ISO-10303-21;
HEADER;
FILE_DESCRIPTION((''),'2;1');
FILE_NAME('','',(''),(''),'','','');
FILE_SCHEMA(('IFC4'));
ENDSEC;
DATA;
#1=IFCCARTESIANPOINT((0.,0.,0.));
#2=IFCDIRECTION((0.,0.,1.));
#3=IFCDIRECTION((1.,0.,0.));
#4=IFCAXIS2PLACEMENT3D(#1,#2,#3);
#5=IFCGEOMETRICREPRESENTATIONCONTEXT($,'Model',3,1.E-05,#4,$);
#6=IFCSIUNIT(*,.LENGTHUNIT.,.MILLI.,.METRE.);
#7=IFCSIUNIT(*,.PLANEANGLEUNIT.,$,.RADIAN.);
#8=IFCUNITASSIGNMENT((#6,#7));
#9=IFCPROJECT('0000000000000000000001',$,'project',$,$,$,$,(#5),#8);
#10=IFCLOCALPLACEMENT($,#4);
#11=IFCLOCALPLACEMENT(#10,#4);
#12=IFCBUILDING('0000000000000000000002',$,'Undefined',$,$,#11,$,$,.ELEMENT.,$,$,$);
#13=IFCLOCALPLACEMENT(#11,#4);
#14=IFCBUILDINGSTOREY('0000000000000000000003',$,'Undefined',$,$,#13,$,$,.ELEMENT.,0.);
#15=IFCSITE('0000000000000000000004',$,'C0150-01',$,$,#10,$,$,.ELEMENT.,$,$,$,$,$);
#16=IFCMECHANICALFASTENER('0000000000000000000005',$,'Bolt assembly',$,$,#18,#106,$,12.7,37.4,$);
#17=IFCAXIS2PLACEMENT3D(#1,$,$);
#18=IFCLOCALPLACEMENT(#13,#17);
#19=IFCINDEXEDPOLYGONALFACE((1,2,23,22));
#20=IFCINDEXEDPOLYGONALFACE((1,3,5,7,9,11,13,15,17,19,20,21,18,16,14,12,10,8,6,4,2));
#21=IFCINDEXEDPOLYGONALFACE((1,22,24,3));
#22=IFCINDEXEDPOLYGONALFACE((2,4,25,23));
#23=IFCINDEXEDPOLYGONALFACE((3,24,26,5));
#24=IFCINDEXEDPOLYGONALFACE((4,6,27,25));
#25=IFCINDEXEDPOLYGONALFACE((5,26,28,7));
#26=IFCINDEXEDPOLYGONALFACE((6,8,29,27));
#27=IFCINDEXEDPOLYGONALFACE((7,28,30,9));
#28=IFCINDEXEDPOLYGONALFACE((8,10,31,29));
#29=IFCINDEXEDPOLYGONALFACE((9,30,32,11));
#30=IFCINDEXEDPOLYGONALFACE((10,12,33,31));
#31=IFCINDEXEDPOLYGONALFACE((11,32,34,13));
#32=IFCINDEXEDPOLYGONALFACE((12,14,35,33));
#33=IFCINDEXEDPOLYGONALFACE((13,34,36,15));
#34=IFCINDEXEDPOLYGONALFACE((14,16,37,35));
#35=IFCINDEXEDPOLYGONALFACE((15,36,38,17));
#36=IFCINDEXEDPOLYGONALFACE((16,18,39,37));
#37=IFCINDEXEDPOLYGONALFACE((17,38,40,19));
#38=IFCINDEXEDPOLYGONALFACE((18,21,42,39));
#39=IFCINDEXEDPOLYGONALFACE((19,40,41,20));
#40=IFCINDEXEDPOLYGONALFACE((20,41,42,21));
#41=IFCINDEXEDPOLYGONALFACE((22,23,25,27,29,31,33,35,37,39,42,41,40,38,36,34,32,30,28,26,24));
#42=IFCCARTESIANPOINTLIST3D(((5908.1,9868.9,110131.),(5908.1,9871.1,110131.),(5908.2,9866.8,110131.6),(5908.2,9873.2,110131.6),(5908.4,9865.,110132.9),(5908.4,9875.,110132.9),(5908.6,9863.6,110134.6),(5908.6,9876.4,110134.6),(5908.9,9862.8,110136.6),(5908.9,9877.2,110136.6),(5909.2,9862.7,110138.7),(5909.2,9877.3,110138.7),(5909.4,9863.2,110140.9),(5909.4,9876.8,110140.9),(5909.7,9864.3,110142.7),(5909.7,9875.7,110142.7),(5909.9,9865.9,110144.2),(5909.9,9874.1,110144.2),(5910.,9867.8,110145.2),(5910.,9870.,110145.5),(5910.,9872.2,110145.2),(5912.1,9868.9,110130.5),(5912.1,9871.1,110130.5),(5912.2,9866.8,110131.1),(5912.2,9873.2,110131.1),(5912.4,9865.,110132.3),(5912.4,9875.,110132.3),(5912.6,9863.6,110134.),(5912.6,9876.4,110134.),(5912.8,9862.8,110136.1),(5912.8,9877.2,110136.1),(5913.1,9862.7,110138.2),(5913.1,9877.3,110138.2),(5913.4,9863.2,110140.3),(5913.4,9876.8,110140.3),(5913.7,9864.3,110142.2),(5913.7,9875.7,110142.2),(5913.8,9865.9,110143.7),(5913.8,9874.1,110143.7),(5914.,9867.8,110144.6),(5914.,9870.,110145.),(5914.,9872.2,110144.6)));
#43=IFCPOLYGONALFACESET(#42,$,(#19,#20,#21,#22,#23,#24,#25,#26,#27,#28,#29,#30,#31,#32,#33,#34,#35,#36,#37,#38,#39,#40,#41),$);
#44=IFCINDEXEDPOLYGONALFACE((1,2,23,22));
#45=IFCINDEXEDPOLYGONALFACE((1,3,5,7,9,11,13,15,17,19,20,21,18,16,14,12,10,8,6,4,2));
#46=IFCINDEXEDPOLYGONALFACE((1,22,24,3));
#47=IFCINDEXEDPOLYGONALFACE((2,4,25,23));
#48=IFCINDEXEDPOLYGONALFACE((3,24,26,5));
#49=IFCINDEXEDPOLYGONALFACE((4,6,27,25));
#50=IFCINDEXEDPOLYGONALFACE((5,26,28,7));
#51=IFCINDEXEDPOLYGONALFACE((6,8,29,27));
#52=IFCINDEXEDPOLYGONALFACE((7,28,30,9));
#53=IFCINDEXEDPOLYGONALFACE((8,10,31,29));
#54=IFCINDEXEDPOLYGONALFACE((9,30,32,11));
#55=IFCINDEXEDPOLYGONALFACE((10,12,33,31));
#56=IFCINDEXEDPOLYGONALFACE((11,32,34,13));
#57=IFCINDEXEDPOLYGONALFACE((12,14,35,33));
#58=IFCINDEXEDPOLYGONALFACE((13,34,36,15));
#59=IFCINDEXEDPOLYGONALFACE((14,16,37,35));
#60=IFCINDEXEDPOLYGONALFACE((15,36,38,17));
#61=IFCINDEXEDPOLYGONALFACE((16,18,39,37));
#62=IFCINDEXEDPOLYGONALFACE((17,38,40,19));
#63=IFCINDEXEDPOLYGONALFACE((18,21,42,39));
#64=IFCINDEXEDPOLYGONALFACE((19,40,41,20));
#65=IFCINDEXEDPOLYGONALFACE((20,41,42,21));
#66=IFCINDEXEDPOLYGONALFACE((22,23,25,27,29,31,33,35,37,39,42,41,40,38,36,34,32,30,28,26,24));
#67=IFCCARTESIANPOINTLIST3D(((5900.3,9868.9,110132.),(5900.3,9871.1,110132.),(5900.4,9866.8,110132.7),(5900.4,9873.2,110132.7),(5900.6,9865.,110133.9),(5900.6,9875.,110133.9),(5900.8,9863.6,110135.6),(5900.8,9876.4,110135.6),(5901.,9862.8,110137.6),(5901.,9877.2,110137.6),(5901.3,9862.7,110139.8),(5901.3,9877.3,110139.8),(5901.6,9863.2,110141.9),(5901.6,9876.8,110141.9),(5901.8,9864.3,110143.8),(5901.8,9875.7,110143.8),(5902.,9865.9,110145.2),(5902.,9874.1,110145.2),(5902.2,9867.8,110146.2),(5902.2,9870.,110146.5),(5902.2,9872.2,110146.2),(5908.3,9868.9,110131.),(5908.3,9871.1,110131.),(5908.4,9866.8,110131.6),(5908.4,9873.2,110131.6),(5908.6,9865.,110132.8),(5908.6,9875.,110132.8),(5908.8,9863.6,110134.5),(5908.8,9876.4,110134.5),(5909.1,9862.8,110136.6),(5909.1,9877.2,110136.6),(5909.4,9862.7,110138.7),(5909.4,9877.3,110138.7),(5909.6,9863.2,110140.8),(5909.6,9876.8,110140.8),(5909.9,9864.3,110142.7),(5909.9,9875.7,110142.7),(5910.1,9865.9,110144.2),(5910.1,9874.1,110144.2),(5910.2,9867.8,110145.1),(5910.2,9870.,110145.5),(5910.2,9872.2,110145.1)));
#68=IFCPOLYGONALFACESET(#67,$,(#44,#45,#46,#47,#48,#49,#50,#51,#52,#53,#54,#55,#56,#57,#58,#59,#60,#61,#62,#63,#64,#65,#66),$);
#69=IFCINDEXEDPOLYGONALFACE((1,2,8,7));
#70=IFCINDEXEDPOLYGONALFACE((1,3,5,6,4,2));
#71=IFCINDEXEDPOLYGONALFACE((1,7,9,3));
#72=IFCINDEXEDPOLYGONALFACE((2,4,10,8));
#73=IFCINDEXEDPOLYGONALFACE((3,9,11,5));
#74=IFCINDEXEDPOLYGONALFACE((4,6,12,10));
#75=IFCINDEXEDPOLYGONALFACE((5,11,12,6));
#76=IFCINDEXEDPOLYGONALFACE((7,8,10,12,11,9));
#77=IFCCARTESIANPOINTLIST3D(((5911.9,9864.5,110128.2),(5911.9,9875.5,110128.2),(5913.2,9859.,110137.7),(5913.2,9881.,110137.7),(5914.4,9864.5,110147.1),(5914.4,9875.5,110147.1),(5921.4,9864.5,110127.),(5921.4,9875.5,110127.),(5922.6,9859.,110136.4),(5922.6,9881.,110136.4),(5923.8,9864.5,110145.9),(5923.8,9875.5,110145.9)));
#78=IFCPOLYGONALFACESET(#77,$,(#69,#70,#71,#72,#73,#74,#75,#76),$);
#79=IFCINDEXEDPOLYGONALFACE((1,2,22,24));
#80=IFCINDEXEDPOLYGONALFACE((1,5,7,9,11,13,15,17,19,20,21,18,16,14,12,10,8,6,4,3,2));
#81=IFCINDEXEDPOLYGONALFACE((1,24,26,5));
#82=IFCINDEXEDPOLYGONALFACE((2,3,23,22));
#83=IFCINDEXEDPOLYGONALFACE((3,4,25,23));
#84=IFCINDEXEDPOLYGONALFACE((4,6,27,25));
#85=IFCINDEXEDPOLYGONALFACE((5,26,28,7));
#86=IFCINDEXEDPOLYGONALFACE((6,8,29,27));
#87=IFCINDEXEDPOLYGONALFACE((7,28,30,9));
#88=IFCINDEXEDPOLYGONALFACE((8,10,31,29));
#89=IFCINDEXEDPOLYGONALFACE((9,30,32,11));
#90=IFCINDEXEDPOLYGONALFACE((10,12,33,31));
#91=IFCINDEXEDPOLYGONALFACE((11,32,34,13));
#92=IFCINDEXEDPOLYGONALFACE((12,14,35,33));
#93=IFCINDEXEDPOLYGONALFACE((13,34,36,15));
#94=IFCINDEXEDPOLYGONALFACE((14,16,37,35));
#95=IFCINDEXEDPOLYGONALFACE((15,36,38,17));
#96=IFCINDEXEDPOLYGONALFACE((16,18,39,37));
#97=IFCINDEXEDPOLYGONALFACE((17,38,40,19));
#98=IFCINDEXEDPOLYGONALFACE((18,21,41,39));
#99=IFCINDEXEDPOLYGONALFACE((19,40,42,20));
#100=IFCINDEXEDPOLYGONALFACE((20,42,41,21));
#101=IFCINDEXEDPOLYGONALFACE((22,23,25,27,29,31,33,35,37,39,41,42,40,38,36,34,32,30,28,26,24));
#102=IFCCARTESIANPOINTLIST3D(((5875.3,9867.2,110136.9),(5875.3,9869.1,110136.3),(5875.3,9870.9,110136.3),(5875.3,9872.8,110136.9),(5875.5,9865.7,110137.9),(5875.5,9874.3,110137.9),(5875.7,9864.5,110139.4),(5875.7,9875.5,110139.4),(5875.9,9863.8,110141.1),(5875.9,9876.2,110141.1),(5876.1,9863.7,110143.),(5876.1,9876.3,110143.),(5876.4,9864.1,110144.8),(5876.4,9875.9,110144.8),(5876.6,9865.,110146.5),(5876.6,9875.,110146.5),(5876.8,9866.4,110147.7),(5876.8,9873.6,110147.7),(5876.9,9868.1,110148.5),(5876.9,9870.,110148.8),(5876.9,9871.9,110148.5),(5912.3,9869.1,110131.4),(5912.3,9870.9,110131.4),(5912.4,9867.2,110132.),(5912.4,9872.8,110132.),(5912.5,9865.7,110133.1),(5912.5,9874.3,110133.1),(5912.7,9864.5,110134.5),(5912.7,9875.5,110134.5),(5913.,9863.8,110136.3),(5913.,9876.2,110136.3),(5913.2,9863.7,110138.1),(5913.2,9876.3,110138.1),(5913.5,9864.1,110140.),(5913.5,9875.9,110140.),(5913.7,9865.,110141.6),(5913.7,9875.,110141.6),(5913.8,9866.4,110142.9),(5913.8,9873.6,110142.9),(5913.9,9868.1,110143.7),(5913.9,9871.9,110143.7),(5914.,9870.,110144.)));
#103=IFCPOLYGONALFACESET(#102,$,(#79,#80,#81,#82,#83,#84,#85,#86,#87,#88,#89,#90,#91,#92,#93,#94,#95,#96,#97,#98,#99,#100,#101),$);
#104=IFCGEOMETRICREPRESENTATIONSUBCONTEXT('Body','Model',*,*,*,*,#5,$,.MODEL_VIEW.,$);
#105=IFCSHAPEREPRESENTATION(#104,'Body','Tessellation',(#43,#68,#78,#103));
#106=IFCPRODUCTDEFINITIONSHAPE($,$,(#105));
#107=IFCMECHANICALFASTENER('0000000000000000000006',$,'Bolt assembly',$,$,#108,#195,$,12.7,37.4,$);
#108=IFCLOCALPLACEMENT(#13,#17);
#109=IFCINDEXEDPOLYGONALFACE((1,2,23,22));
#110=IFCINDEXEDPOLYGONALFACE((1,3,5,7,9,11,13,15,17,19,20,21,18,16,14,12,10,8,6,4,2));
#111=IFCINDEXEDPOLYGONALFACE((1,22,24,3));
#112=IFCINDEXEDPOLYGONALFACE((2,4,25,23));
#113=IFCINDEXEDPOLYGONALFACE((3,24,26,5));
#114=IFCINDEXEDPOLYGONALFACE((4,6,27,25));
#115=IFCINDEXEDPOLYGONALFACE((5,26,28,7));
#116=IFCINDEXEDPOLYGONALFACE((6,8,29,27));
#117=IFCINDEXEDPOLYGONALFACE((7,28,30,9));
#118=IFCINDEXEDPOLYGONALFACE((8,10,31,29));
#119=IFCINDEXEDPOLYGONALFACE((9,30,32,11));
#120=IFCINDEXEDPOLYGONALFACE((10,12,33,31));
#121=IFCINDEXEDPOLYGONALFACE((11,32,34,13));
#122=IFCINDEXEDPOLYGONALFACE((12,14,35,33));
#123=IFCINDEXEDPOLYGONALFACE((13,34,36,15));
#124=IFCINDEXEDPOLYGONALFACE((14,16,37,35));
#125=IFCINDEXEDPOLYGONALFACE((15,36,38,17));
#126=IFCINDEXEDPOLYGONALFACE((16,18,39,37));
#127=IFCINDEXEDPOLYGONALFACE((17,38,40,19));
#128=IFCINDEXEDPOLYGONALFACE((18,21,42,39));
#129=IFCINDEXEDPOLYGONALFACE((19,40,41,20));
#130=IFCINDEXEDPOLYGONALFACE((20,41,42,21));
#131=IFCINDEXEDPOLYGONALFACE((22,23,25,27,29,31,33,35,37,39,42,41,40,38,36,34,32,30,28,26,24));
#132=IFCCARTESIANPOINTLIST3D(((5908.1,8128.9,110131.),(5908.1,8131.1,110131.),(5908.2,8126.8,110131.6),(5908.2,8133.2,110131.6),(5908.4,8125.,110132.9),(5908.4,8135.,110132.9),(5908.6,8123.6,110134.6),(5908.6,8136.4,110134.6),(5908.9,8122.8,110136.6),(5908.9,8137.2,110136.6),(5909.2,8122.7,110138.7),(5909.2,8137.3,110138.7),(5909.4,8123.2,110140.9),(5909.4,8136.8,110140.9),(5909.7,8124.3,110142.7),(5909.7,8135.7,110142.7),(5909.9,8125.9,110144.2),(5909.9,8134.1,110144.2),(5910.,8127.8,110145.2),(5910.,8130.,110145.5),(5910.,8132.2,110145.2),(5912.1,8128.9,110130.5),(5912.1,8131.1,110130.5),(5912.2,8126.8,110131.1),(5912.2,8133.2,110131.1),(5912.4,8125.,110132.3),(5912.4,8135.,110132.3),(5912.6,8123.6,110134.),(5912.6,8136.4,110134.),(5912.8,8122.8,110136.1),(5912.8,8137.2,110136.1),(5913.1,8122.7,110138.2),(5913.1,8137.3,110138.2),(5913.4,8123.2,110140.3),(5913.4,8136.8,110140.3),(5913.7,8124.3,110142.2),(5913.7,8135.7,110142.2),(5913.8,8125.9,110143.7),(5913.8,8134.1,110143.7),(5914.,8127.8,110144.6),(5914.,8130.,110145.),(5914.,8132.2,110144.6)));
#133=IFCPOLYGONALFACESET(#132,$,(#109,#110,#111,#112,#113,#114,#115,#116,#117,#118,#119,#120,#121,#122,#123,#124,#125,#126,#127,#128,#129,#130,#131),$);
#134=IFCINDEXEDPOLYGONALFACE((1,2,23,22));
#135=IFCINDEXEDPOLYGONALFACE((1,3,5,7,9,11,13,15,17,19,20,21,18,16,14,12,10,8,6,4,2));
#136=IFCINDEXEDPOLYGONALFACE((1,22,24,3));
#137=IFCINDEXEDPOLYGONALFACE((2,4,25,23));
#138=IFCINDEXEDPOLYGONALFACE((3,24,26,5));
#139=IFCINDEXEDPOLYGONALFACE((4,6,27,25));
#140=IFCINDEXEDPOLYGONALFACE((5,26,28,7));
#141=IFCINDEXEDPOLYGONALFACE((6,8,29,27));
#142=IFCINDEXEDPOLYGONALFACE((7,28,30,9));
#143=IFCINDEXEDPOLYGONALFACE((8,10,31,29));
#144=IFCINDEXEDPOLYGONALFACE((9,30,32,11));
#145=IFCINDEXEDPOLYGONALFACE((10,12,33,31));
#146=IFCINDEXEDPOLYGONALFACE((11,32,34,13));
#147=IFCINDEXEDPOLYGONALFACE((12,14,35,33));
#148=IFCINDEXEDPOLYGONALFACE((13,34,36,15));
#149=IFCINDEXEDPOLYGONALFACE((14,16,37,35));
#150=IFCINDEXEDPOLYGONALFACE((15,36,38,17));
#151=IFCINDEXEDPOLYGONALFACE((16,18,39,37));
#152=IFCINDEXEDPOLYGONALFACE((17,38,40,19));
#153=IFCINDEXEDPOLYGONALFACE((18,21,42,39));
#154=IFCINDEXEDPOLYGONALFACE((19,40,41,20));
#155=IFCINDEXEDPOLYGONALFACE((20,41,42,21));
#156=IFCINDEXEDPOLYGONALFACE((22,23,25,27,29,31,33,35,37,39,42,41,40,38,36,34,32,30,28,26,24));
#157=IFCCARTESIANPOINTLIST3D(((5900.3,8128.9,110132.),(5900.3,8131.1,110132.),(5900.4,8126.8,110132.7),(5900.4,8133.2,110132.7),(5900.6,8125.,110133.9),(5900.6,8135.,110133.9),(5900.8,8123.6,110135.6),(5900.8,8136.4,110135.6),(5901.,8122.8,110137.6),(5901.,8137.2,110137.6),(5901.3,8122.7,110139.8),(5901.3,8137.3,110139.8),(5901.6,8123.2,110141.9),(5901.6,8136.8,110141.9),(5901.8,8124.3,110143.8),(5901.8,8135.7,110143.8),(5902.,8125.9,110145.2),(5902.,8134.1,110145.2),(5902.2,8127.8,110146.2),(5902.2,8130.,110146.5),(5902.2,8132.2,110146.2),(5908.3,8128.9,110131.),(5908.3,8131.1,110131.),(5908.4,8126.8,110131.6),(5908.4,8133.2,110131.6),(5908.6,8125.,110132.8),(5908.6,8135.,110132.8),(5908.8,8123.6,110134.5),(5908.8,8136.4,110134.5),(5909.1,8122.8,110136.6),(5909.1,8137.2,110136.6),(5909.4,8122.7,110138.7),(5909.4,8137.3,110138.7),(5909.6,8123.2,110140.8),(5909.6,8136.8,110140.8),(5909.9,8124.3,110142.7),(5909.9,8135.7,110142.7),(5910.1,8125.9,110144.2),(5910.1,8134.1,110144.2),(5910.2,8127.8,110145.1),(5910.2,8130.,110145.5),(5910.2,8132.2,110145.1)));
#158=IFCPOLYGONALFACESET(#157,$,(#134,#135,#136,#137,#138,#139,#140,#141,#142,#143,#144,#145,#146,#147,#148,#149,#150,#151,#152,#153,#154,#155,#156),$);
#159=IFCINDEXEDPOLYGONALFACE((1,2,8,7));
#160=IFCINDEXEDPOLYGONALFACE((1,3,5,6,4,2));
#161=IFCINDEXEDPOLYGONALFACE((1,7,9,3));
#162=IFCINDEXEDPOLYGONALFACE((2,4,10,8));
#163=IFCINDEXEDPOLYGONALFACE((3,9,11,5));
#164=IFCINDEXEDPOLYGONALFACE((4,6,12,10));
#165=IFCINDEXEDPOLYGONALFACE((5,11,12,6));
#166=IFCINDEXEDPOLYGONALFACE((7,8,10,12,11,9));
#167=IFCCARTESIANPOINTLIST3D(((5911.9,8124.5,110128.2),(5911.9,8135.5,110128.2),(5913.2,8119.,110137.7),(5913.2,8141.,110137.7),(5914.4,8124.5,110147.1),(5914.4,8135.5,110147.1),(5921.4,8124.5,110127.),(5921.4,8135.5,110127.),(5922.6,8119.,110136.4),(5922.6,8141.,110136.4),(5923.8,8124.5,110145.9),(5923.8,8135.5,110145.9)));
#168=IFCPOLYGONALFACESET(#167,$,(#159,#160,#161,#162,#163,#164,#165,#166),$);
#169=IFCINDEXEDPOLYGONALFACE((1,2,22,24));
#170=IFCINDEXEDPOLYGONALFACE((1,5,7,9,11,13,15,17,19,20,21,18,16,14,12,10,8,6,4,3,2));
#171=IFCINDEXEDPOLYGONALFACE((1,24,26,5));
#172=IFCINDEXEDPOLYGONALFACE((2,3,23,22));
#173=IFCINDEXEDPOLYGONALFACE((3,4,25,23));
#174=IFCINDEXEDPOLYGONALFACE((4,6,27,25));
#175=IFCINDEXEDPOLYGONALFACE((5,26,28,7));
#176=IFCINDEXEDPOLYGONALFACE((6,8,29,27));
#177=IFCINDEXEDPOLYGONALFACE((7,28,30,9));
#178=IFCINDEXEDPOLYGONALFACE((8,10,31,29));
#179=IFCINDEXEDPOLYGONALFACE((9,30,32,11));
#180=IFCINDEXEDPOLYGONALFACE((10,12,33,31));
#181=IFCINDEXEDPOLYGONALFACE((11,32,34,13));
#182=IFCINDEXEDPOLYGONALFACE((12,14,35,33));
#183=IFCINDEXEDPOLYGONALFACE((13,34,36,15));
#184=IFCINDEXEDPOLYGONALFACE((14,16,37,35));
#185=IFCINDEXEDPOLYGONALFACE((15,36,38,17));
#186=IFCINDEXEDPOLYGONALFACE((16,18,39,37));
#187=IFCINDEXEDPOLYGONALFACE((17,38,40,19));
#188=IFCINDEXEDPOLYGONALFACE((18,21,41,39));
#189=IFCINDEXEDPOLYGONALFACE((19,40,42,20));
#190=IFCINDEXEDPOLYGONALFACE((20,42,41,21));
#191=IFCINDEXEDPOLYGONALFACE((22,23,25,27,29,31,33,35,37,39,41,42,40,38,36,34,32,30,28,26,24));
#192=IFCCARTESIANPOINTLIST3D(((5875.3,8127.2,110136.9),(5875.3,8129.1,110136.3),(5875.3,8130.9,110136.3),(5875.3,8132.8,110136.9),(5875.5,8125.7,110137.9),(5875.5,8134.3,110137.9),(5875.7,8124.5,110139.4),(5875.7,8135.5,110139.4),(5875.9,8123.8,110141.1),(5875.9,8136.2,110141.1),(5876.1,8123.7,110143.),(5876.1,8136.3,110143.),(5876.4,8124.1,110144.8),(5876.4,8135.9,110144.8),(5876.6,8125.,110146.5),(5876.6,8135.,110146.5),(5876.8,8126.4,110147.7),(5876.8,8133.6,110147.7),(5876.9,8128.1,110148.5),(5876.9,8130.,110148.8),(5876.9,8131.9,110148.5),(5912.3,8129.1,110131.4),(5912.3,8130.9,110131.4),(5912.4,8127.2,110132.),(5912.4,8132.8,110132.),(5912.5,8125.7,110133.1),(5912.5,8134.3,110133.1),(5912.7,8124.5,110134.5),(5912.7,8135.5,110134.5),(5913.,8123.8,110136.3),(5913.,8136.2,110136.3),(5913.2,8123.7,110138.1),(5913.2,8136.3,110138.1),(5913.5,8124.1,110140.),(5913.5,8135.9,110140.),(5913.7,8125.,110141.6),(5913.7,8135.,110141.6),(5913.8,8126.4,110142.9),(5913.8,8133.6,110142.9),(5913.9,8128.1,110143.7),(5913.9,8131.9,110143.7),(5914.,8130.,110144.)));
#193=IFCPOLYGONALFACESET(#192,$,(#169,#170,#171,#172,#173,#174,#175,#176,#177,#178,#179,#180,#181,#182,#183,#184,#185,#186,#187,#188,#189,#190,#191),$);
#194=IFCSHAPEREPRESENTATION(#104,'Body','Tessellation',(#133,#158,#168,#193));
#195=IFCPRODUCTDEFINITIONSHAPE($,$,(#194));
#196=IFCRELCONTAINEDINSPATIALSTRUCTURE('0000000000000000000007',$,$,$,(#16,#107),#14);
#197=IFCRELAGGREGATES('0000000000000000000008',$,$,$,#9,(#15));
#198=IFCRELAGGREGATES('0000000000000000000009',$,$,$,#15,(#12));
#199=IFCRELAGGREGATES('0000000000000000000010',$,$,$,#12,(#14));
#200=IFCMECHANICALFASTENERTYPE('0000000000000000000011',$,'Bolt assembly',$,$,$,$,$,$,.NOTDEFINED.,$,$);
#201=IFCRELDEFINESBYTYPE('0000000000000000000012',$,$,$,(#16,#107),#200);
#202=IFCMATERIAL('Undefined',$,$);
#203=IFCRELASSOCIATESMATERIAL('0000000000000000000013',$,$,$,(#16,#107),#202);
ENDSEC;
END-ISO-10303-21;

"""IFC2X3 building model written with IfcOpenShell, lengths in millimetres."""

from ifc_helpers import new_model, si_unit, frame, origin_with_axes, origin_2d_with_axis, place, context, subcontext, project, spatial, polyline, circle, outline, extrude, source, transform, mapped, material, type_object, element, save


model = new_model("IFC2X3")

# Units and contexts
model_context = context("Model", 3, precision=1e-05, world=origin_with_axes())
body_context = subcontext(model_context, "Body", "Model", "MODEL_VIEW")
ifc_project = project(units=[si_unit("LENGTHUNIT", "METRE", prefix="MILLI"), si_unit("PLANEANGLEUNIT", "RADIAN")], contexts=[model_context])

# Site, building, storey
site_placement = place(None, origin_with_axes())
site = spatial("IfcSite", under=ifc_project, at=site_placement, Name="C0150-01", CompositionType="ELEMENT")
building_placement = place(site_placement, origin_with_axes())
building = spatial("IfcBuilding", under=site, at=building_placement, Name="Undefined", CompositionType="ELEMENT")
storey_placement = place(building_placement, origin_with_axes())
storey = spatial("IfcBuildingStorey", under=building, at=storey_placement, Name="Undefined", CompositionType="ELEMENT", Elevation=0.0)

# Mechanical fasteners
ifc_material_1 = material(Name="Undefined")
mechanical_fastener_type = type_object("IfcMechanicalFastenerType", Name="Bolt assembly")
shared_shape_1 = source(origin_with_axes(), body_context, "Body", "SweptSolid", [
    extrude(circle(Radius=7.3, at=origin_2d_with_axis()), frame((0.0, -3.9, 0.0), z_axis=(0.0, 1.0, 0.0), x_axis=(1.0, 0.0, 0.0)), (0.0, 0.0, 1.0), 4.0),
    extrude(circle(Radius=7.3, at=origin_2d_with_axis()), frame((0.0, -0.1, 0.0), z_axis=(0.0, 1.0, 0.0), x_axis=(1.0, 0.0, 0.0)), (0.0, 0.0, 1.0), 8.1),
    extrude(outline(polyline([(9.5, -5.5), (9.5, 5.5), (0.0, 11.0), (-9.5, 5.5), (-9.5, -5.5), (0.0, -11.0), (9.5, -5.5)])), frame((0.0, -13.5, 0.0), z_axis=(0.0, 1.0, 0.0), x_axis=(1.0, 0.0, 0.0)), (0.0, 0.0, 1.0), 9.5),
    extrude(circle(Radius=6.3, at=origin_2d_with_axis()), frame((0.0, -4.0, 0.0), z_axis=(0.0, 1.0, 0.0), x_axis=(1.0, 0.0, 0.0)), (0.0, 0.0, 1.0), 37.4),
])
for number, where, z_axis, x_axis, name in (
    (1, (5909.2, 9870.0, 110138.2), (0.0, -1.0, 0.0), (0.130054, 0.0, 0.991507), "Bolt assembly"),
    (2, (5909.2, 8130.0, 110138.2), (0.0, -1.0, 0.0), (0.130054, 0.0, 0.991507), "Bolt assembly"),
):
    element("IfcMechanicalFastener", number, at=place(storey_placement, frame(where, z_axis=z_axis, x_axis=x_axis)), inside=storey, type_object=mechanical_fastener_type, material=ifc_material_1, Name=name, NominalDiameter=12.7, NominalLength=37.4, context=body_context, shape_type="MappedRepresentation", body=[
        mapped(shared_shape_1, transform((0.0, 0.0, 0.0))),
    ])

save(model, "model.ifc")
